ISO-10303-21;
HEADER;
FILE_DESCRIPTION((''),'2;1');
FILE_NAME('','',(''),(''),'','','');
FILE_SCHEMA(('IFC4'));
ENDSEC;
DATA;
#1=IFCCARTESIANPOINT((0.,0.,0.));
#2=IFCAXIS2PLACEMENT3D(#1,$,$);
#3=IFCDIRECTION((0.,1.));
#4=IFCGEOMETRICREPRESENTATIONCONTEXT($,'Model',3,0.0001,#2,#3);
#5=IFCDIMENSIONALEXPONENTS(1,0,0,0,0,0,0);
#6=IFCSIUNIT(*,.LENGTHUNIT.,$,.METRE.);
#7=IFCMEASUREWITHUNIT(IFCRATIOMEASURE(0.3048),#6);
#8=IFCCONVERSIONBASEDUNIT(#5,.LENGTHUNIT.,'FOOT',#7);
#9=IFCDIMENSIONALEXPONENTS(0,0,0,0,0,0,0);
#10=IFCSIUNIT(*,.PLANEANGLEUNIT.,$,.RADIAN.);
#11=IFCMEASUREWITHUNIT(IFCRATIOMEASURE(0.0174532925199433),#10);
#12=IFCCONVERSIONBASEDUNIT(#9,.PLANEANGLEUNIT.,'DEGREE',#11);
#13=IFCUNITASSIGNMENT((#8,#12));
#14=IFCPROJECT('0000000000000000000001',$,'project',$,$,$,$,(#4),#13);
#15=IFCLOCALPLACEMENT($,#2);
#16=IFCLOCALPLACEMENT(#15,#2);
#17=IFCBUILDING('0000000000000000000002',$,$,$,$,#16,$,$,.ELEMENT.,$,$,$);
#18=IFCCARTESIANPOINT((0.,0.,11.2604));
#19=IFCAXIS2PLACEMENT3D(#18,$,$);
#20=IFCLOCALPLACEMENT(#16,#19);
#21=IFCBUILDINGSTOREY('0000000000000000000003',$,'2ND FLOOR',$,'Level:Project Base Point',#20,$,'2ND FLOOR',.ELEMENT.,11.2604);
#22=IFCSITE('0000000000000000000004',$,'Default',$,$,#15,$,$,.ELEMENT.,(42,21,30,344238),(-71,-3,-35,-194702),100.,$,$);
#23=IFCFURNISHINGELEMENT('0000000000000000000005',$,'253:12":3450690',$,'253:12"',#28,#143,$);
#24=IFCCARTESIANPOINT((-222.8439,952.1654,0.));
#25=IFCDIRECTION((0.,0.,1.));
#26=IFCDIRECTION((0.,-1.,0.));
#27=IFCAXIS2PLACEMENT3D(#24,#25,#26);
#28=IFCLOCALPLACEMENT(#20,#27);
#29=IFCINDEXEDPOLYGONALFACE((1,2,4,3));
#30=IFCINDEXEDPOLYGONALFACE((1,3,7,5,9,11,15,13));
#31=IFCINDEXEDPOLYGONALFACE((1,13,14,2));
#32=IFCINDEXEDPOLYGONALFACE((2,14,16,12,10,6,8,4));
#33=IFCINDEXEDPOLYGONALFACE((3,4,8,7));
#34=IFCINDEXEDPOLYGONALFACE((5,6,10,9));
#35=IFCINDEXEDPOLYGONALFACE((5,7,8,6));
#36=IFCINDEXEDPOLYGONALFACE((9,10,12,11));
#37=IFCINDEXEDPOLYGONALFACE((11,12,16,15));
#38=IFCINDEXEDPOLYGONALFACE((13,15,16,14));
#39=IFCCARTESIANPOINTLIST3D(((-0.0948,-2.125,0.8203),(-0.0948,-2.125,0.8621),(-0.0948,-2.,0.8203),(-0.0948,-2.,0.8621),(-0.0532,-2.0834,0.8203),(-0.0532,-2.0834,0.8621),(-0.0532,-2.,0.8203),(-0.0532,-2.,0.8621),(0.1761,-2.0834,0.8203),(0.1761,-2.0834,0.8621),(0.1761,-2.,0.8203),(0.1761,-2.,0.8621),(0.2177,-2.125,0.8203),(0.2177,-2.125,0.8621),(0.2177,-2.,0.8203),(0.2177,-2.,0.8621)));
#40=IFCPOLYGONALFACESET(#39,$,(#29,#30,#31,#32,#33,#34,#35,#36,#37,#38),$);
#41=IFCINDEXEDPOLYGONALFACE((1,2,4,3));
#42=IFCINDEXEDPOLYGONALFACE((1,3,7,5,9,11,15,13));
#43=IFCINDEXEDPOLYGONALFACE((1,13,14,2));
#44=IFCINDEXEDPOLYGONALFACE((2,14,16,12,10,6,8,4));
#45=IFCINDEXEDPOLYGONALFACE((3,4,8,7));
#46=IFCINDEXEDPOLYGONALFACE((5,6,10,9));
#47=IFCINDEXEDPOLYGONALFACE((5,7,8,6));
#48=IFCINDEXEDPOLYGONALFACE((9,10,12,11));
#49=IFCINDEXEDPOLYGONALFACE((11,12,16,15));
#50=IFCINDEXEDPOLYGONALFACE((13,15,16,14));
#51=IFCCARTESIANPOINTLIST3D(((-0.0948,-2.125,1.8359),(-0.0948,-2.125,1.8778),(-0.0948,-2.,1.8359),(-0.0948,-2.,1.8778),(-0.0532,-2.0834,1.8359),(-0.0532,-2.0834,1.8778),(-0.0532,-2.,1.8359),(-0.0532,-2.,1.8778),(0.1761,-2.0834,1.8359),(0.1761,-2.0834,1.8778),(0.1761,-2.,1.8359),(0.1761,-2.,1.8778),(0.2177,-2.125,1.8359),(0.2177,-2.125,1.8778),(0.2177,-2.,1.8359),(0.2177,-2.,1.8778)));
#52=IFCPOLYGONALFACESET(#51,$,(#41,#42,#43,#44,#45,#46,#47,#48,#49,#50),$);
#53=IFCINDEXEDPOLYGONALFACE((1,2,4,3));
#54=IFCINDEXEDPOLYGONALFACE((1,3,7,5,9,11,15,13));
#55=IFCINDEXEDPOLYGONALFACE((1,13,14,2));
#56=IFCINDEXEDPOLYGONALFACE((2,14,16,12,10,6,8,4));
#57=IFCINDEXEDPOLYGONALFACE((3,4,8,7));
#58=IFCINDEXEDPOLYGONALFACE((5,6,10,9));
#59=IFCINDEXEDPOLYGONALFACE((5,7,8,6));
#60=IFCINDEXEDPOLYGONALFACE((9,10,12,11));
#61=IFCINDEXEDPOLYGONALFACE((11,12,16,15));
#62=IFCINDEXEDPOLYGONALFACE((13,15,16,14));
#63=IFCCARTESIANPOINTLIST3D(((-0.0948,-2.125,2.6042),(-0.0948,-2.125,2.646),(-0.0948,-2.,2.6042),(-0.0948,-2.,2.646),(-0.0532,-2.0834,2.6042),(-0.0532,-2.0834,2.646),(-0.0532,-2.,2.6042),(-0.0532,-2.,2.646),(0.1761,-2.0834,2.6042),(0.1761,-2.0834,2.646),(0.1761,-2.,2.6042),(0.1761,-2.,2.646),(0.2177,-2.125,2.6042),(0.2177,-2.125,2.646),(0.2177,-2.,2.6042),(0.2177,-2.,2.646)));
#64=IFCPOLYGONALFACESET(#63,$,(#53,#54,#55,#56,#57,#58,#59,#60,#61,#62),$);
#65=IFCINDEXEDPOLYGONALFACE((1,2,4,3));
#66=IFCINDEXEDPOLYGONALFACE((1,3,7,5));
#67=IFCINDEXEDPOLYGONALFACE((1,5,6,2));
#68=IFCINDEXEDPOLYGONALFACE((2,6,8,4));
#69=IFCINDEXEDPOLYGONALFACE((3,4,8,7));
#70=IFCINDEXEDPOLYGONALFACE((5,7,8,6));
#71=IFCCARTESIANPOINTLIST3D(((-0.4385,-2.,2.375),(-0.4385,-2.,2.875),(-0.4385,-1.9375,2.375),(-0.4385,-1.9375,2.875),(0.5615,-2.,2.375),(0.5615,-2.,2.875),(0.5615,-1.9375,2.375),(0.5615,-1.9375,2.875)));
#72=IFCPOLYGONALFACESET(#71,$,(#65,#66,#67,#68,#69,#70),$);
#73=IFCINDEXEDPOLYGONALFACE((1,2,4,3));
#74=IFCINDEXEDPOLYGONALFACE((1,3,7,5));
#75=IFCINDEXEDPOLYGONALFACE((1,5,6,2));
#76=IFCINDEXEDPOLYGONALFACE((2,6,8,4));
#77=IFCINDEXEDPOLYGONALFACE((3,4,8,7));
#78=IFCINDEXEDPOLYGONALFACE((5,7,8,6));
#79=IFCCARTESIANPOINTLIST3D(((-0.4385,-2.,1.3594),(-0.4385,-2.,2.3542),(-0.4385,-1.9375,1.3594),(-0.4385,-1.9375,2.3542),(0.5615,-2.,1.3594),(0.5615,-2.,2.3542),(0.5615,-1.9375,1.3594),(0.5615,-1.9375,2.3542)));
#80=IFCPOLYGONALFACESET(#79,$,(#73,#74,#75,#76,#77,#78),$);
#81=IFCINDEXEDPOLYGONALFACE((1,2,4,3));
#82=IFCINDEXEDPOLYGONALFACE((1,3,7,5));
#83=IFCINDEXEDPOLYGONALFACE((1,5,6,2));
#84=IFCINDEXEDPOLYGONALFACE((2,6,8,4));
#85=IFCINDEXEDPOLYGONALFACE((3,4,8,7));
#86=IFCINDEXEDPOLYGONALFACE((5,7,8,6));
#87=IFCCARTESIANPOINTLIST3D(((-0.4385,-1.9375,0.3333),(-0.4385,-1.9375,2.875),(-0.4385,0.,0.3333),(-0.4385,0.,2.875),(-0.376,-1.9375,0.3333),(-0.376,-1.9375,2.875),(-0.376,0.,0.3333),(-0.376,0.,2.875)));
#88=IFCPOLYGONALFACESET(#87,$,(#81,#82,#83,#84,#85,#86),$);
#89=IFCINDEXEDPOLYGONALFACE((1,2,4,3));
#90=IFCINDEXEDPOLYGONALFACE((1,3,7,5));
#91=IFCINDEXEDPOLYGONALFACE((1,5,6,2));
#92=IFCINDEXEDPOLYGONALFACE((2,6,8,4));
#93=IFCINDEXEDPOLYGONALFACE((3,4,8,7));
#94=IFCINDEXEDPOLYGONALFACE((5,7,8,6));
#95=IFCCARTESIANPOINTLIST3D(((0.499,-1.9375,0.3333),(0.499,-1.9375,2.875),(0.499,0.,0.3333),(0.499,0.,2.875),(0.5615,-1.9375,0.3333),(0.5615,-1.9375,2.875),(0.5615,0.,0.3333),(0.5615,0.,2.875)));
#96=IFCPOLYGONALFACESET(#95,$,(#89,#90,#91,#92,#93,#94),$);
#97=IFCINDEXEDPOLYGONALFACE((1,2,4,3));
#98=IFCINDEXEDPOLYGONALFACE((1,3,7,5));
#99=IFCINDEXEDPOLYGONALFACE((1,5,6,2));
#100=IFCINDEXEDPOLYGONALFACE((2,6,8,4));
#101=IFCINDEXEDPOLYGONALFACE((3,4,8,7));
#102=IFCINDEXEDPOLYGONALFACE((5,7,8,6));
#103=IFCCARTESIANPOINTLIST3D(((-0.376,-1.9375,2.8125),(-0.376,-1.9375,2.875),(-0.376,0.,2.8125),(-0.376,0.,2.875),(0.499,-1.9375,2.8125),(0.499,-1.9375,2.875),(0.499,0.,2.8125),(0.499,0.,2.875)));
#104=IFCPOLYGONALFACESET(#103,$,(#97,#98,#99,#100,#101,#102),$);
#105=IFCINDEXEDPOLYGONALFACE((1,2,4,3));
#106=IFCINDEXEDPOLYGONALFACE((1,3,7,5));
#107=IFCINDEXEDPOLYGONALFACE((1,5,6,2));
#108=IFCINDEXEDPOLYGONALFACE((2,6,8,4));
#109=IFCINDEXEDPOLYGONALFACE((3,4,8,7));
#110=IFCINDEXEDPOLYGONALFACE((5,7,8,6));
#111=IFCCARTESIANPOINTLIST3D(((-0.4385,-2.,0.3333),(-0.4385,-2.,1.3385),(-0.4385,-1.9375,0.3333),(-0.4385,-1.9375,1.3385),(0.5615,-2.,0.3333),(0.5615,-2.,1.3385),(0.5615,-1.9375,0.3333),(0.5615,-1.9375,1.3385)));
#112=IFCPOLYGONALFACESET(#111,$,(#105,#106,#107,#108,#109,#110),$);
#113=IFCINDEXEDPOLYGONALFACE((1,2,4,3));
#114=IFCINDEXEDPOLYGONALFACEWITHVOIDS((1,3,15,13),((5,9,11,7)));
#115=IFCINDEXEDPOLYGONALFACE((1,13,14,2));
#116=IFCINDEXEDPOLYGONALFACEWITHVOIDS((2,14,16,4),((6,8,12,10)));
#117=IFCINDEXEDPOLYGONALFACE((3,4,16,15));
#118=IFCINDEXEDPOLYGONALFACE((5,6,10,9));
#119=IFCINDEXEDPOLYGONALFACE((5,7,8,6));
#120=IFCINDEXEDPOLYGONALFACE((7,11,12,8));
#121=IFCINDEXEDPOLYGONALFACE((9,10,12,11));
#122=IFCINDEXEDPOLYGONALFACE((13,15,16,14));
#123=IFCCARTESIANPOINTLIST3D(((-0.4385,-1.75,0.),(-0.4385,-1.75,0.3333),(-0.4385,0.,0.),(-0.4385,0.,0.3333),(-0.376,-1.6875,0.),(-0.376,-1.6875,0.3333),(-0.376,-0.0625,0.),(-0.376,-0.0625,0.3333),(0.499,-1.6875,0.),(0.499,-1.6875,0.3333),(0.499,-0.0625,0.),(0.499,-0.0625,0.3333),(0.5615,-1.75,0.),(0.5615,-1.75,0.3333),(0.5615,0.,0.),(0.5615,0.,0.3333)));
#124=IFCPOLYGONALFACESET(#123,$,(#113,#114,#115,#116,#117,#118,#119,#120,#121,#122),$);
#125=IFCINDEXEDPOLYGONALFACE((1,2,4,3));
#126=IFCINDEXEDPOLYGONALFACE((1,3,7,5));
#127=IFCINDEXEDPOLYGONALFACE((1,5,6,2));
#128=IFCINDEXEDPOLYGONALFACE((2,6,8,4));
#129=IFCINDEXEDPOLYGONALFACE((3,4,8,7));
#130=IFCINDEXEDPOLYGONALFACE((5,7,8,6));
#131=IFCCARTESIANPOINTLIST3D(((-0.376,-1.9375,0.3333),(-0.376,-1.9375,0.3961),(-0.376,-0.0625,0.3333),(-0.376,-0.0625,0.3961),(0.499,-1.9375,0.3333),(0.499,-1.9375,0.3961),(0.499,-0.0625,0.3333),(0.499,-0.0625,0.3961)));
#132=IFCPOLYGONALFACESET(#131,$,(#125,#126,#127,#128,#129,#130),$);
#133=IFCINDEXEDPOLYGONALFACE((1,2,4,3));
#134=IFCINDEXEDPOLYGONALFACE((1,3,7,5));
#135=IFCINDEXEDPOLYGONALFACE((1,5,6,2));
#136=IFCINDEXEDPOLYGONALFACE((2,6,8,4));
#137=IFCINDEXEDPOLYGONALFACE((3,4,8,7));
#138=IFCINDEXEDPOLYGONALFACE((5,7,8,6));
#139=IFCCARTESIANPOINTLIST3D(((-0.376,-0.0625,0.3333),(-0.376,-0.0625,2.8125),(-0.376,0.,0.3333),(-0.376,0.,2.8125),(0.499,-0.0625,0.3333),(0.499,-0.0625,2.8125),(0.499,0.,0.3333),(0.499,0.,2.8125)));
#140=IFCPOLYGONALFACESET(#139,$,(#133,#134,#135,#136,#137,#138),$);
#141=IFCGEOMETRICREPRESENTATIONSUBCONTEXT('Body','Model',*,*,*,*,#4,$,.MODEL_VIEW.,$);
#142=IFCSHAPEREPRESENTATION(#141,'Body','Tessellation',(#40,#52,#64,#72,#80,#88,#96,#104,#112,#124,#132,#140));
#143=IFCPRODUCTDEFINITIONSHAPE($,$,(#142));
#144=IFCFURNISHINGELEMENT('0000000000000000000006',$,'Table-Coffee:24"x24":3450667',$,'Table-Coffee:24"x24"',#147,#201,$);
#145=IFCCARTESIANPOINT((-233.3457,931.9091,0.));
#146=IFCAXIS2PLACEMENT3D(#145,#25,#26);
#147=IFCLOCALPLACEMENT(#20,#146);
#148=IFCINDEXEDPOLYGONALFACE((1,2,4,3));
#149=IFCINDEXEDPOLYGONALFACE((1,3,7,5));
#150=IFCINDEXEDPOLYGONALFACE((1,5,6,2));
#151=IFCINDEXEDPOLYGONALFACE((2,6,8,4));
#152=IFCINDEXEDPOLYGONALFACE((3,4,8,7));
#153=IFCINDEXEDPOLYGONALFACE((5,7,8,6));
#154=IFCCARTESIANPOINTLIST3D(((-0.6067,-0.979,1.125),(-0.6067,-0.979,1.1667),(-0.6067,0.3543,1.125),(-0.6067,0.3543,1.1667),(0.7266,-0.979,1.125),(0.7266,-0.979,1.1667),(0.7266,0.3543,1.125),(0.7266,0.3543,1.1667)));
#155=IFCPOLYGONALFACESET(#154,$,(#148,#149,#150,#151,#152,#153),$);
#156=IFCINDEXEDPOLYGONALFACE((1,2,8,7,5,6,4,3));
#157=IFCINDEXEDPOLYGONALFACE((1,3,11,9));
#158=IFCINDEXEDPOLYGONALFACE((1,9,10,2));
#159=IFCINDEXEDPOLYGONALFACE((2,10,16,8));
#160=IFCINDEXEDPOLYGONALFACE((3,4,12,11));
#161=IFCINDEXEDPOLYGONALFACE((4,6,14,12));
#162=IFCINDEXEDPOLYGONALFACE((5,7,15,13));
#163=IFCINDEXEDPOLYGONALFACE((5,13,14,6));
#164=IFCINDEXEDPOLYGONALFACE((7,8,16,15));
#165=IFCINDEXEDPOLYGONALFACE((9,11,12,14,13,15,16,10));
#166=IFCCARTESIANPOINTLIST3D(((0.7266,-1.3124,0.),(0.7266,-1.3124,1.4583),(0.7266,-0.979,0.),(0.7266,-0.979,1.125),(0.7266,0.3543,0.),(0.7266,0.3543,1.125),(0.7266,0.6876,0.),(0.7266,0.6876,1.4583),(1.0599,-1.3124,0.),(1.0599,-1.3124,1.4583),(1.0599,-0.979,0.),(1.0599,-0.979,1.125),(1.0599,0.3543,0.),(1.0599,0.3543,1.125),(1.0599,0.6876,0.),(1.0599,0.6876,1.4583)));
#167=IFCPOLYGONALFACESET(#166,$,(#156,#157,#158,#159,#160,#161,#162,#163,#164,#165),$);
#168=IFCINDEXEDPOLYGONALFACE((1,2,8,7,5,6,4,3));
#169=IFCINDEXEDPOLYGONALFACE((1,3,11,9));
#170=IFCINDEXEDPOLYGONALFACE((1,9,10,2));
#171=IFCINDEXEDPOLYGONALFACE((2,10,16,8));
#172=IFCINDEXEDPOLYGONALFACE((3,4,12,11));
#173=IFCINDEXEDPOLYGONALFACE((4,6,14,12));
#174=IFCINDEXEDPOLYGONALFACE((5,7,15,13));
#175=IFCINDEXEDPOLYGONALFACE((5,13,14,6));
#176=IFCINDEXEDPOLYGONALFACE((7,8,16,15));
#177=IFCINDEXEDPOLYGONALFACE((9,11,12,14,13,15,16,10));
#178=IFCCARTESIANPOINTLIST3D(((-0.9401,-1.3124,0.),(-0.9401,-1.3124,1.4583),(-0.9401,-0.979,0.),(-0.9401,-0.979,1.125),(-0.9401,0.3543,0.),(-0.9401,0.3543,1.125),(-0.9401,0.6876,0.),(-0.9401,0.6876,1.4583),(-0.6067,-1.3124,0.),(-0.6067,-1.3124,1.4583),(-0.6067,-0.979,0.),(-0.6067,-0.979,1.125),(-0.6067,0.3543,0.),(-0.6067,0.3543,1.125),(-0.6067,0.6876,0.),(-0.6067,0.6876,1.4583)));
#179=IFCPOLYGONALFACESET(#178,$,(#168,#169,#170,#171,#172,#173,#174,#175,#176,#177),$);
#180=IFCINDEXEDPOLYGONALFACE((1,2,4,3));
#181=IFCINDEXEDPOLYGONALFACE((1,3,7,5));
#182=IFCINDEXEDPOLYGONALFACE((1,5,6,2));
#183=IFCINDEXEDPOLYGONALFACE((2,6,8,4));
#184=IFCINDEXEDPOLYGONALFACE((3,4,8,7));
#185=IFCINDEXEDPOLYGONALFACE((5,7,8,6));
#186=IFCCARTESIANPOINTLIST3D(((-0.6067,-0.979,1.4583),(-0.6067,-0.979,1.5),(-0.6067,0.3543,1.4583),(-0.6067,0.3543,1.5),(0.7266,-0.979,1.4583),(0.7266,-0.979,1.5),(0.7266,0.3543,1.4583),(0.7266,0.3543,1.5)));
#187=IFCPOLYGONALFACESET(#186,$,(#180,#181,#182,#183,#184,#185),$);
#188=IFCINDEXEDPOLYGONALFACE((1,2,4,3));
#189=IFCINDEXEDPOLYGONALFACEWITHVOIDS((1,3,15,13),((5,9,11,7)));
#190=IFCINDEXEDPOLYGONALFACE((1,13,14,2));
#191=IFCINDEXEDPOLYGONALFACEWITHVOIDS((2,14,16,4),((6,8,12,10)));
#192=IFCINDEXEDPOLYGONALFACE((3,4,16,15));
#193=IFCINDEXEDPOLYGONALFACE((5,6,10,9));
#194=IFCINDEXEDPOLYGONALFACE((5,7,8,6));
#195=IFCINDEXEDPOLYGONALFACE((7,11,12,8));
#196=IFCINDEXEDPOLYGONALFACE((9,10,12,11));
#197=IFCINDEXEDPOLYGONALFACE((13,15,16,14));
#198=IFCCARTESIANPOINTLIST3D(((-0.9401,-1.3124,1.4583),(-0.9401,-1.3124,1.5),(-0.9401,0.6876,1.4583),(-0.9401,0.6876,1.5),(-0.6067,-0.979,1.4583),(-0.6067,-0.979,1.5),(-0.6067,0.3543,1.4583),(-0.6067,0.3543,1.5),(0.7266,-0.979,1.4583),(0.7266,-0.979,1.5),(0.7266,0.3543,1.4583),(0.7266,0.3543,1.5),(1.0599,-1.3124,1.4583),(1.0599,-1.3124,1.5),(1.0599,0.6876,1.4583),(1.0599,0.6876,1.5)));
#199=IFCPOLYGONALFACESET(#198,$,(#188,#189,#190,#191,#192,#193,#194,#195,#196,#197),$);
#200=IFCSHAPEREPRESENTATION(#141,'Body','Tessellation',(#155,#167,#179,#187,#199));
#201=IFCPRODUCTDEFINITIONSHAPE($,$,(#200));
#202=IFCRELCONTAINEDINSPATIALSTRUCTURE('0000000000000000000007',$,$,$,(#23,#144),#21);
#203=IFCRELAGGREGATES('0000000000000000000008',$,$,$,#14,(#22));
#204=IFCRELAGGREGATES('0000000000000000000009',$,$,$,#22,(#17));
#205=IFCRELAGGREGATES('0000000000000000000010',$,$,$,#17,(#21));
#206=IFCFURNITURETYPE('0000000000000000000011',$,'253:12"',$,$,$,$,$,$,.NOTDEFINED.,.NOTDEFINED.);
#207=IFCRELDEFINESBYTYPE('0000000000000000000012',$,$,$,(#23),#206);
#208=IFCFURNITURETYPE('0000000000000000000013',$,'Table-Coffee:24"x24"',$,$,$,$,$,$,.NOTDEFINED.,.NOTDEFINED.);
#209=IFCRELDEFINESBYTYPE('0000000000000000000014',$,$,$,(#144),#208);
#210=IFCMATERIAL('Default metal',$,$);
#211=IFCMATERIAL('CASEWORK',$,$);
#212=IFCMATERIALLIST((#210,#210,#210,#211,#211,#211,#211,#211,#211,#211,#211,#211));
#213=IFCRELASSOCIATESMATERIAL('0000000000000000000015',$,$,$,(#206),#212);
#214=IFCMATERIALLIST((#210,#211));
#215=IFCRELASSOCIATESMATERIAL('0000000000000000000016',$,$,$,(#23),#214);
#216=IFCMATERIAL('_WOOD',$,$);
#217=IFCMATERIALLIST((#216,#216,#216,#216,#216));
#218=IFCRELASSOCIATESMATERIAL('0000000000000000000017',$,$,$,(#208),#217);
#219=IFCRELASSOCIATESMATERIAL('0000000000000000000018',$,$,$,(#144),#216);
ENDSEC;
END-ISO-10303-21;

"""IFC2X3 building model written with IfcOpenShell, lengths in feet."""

from ifc_helpers import new_model, entity, si_unit, converted_unit, direction, frame, frame_2d, origin, origin_2d_with_axis, place, context, subcontext, project, spatial, polyline, rectangle, outline, extrude, source, transform, mapped, material, material_list, type_object, type_shapes, element, save


model = new_model("IFC2X3")

# Units and contexts
model_context = context("Model", 3, precision=0.0001, world=origin(), true_north=direction((0.0, 1.0)))
body_context = subcontext(model_context, "Body", "Model", "MODEL_VIEW")
ifc_project = project(units=[converted_unit("LENGTHUNIT", "FOOT", entity("IfcRatioMeasure", 0.3048), si_unit("LENGTHUNIT", "METRE"), dimensions=[1, 0, 0, 0, 0, 0, 0]), converted_unit("PLANEANGLEUNIT", "DEGREE", entity("IfcRatioMeasure", 0.0174532925199433), si_unit("PLANEANGLEUNIT", "RADIAN"), dimensions=[0, 0, 0, 0, 0, 0, 0])], contexts=[model_context])

# Site, building, storey
site_placement = place(None, origin())
site = spatial("IfcSite", under=ifc_project, at=site_placement, Name="Default", CompositionType="ELEMENT", RefLatitude=(42, 21, 30, 344238), RefLongitude=(-71, -3, -35, -194702), RefElevation=100.0)
building_placement = place(site_placement, origin())
building = spatial("IfcBuilding", under=site, at=building_placement, CompositionType="ELEMENT")
storey_placement = place(building_placement, frame((0.0, 0.0, 11.2604)))
storey = spatial("IfcBuildingStorey", under=building, at=storey_placement, Name="2ND FLOOR", ObjectType="Level:Project Base Point", LongName="2ND FLOOR", CompositionType="ELEMENT", Elevation=11.2604)

# Furnishing elements
ifc_material_1 = material(Name="Default metal")
ifc_material_2 = material(Name="CASEWORK")
ifc_material_list_1 = material_list([ifc_material_1, ifc_material_1, ifc_material_1, ifc_material_2, ifc_material_2, ifc_material_2, ifc_material_2, ifc_material_2, ifc_material_2, ifc_material_2, ifc_material_2, ifc_material_2])
furniture_type_1 = type_object("IfcFurnitureType", Name="253:12\"", material=ifc_material_list_1)
shared_shape_1 = source(origin(), body_context, "Body", "SweptSolid", [
    extrude(outline(polyline([(-0.0521, -0.1562), (0.0729, -0.1562), (0.0729, 0.1562), (-0.0521, 0.1562), (-0.0521, 0.1146), (0.0313, 0.1146), (0.0313, -0.1146), (-0.0521, -0.1146), (-0.0521, -0.1562)])), frame((0.0615, -2.0521, 0.8203), z_axis=(0.0, 0.0, 1.0), x_axis=(0.0, -1.0, 0.0)), (0.0, 0.0, 1.0), 0.0418),
    extrude(outline(polyline([(-0.0521, -0.1562), (0.0729, -0.1562), (0.0729, 0.1562), (-0.0521, 0.1562), (-0.0521, 0.1146), (0.0313, 0.1146), (0.0313, -0.1146), (-0.0521, -0.1146), (-0.0521, -0.1562)])), frame((0.0615, -2.0521, 1.8359), z_axis=(0.0, 0.0, 1.0), x_axis=(0.0, -1.0, 0.0)), (0.0, 0.0, 1.0), 0.0418),
    extrude(outline(polyline([(-0.0521, -0.1562), (0.0729, -0.1562), (0.0729, 0.1562), (-0.0521, 0.1562), (-0.0521, 0.1146), (0.0313, 0.1146), (0.0313, -0.1146), (-0.0521, -0.1146), (-0.0521, -0.1562)])), frame((0.0615, -2.0521, 2.6042), z_axis=(0.0, 0.0, 1.0), x_axis=(0.0, -1.0, 0.0)), (0.0, 0.0, 1.0), 0.0418),
    extrude(rectangle(XDim=0.0625, YDim=1.0, at=origin_2d_with_axis()), frame((0.0615, -1.9688, 2.375), z_axis=(0.0, 0.0, 1.0), x_axis=(0.0, 1.0, 0.0)), (0.0, 0.0, 1.0), 0.5),
    extrude(rectangle(XDim=0.0625, YDim=1.0, at=origin_2d_with_axis()), frame((0.0615, -1.9688, 1.3594), z_axis=(0.0, 0.0, 1.0), x_axis=(0.0, 1.0, 0.0)), (0.0, 0.0, 1.0), 0.9948),
    extrude(rectangle(XDim=0.0625, YDim=1.9375, at=frame_2d((0.0, 0.0), x_axis=(1.0, 0.0))), frame((-0.4073, -0.9687, 0.3333)), (0.0, 0.0, 1.0), 2.5417),
    extrude(rectangle(XDim=0.0625, YDim=1.9375, at=frame_2d((0.0, 0.0), x_axis=(1.0, 0.0))), frame((0.5302, -0.9687, 0.3333)), (0.0, 0.0, 1.0), 2.5417),
    extrude(rectangle(XDim=0.875, YDim=1.9375, at=origin_2d_with_axis()), frame((0.0615, -0.9688, 2.8125), z_axis=(0.0, 0.0, 1.0), x_axis=(-1.0, 0.0, 0.0)), (0.0, 0.0, 1.0), 0.0625),
    extrude(rectangle(XDim=0.0625, YDim=1.0, at=origin_2d_with_axis()), frame((0.0615, -1.9688, 0.3333), z_axis=(0.0, 0.0, 1.0), x_axis=(0.0, 1.0, 0.0)), (0.0, 0.0, 1.0), 1.0052),
    extrude(outline(polyline([(-0.5, -0.875), (0.5, -0.875), (0.5, 0.875), (-0.5, 0.875), (-0.5, -0.875)]), holes=[polyline([(-0.4375, -0.8125), (-0.4375, 0.8125), (0.4375, 0.8125), (0.4375, -0.8125), (-0.4375, -0.8125)])]), frame((0.0615, -0.875, 0.0)), (0.0, 0.0, 1.0), 0.3333),
    extrude(rectangle(XDim=0.875, YDim=1.875, at=frame_2d((0.0, 0.0), x_axis=(1.0, 0.0))), frame((0.0615, -1.0, 0.3333), z_axis=(0.0, 0.0, 1.0), x_axis=(-1.0, 0.0, 0.0)), (0.0, 0.0, 1.0), 0.0627),
    extrude(rectangle(XDim=0.0625, YDim=0.875, at=origin_2d_with_axis()), frame((0.0615, -0.0312, 0.3333), z_axis=(0.0, 0.0, 1.0), x_axis=(0.0, 1.0, 0.0)), (0.0, 0.0, 1.0), 2.4792),
])
type_shapes(furniture_type_1, [shared_shape_1])
ifc_material_list_2 = material_list([ifc_material_1, ifc_material_2])
furnishing_1_placement = place(storey_placement, frame((-222.8439, 952.1654, 0.0), z_axis=(0.0, 0.0, 1.0), x_axis=(0.0, -1.0, 0.0)))
element("IfcFurnishingElement", 1, at=furnishing_1_placement, inside=storey, type_object=furniture_type_1, material=ifc_material_list_2, Name="253:12\":3450690", ObjectType="253:12\"", context=body_context, shape_type="MappedRepresentation", body=[
    mapped(shared_shape_1, transform((0.0, 0.0, 0.0), scale=1.0)),
])
ifc_material_3 = material(Name="_WOOD")
ifc_material_list_3 = material_list([ifc_material_3, ifc_material_3, ifc_material_3, ifc_material_3, ifc_material_3])
furniture_type_2 = type_object("IfcFurnitureType", Name="Table-Coffee:24\"x24\"", material=ifc_material_list_3)
shared_shape_2 = source(origin(), body_context, "Body", "SweptSolid", [
    extrude(rectangle(XDim=1.3333, YDim=1.3333, at=origin_2d_with_axis()), frame((0.0599, -0.3124, 1.125), z_axis=(0.0, 0.0, 1.0), x_axis=(0.0, 1.0, 0.0)), (0.0, 0.0, 1.0), 0.0417),
    extrude(outline(polyline([(-1.0, -0.6458), (-0.6667, -0.6458), (-0.6667, 0.4792), (0.6667, 0.4792), (0.6667, -0.6458), (1.0, -0.6458), (1.0, 0.8125), (-1.0, 0.8125), (-1.0, -0.6458)])), frame((0.7266, -0.3124, 0.6458), z_axis=(1.0, 0.0, 0.0), x_axis=(0.0, 1.0, 0.0)), (0.0, 0.0, 1.0), 0.3333),
    extrude(outline(polyline([(-0.8125, -1.0), (0.6458, -1.0), (0.6458, -0.6667), (-0.4792, -0.6667), (-0.4792, 0.6667), (0.6458, 0.6667), (0.6458, 1.0), (-0.8125, 1.0), (-0.8125, -1.0)])), frame((-0.9401, -0.3124, 0.6458), z_axis=(1.0, 0.0, 0.0), x_axis=(0.0, 0.0, -1.0)), (0.0, 0.0, 1.0), 0.3333),
    extrude(rectangle(XDim=1.3333, YDim=1.3333, at=origin_2d_with_axis()), frame((0.0599, -0.3124, 1.4583), z_axis=(0.0, 0.0, 1.0), x_axis=(0.0, 1.0, 0.0)), (0.0, 0.0, 1.0), 0.0417),
    extrude(outline(polyline([(-1.0, -1.0), (1.0, -1.0), (1.0, 1.0), (-1.0, 1.0), (-1.0, -1.0)]), holes=[polyline([(-0.6667, -0.6667), (-0.6667, 0.6667), (0.6667, 0.6667), (0.6667, -0.6667), (-0.6667, -0.6667)])]), frame((0.0599, -0.3124, 1.4583), z_axis=(0.0, 0.0, 1.0), x_axis=(0.0, 1.0, 0.0)), (0.0, 0.0, 1.0), 0.0417),
])
type_shapes(furniture_type_2, [shared_shape_2])
furnishing_2_placement = place(storey_placement, frame((-233.3457, 931.9091, 0.0), z_axis=(0.0, 0.0, 1.0), x_axis=(0.0, -1.0, 0.0)))
element("IfcFurnishingElement", 2, at=furnishing_2_placement, inside=storey, type_object=furniture_type_2, material=ifc_material_3, Name="Table-Coffee:24\"x24\":3450667", ObjectType="Table-Coffee:24\"x24\"", context=body_context, shape_type="MappedRepresentation", body=[
    mapped(shared_shape_2, transform((0.0, 0.0, 0.0), scale=1.0)),
])

save(model, "model.ifc")
